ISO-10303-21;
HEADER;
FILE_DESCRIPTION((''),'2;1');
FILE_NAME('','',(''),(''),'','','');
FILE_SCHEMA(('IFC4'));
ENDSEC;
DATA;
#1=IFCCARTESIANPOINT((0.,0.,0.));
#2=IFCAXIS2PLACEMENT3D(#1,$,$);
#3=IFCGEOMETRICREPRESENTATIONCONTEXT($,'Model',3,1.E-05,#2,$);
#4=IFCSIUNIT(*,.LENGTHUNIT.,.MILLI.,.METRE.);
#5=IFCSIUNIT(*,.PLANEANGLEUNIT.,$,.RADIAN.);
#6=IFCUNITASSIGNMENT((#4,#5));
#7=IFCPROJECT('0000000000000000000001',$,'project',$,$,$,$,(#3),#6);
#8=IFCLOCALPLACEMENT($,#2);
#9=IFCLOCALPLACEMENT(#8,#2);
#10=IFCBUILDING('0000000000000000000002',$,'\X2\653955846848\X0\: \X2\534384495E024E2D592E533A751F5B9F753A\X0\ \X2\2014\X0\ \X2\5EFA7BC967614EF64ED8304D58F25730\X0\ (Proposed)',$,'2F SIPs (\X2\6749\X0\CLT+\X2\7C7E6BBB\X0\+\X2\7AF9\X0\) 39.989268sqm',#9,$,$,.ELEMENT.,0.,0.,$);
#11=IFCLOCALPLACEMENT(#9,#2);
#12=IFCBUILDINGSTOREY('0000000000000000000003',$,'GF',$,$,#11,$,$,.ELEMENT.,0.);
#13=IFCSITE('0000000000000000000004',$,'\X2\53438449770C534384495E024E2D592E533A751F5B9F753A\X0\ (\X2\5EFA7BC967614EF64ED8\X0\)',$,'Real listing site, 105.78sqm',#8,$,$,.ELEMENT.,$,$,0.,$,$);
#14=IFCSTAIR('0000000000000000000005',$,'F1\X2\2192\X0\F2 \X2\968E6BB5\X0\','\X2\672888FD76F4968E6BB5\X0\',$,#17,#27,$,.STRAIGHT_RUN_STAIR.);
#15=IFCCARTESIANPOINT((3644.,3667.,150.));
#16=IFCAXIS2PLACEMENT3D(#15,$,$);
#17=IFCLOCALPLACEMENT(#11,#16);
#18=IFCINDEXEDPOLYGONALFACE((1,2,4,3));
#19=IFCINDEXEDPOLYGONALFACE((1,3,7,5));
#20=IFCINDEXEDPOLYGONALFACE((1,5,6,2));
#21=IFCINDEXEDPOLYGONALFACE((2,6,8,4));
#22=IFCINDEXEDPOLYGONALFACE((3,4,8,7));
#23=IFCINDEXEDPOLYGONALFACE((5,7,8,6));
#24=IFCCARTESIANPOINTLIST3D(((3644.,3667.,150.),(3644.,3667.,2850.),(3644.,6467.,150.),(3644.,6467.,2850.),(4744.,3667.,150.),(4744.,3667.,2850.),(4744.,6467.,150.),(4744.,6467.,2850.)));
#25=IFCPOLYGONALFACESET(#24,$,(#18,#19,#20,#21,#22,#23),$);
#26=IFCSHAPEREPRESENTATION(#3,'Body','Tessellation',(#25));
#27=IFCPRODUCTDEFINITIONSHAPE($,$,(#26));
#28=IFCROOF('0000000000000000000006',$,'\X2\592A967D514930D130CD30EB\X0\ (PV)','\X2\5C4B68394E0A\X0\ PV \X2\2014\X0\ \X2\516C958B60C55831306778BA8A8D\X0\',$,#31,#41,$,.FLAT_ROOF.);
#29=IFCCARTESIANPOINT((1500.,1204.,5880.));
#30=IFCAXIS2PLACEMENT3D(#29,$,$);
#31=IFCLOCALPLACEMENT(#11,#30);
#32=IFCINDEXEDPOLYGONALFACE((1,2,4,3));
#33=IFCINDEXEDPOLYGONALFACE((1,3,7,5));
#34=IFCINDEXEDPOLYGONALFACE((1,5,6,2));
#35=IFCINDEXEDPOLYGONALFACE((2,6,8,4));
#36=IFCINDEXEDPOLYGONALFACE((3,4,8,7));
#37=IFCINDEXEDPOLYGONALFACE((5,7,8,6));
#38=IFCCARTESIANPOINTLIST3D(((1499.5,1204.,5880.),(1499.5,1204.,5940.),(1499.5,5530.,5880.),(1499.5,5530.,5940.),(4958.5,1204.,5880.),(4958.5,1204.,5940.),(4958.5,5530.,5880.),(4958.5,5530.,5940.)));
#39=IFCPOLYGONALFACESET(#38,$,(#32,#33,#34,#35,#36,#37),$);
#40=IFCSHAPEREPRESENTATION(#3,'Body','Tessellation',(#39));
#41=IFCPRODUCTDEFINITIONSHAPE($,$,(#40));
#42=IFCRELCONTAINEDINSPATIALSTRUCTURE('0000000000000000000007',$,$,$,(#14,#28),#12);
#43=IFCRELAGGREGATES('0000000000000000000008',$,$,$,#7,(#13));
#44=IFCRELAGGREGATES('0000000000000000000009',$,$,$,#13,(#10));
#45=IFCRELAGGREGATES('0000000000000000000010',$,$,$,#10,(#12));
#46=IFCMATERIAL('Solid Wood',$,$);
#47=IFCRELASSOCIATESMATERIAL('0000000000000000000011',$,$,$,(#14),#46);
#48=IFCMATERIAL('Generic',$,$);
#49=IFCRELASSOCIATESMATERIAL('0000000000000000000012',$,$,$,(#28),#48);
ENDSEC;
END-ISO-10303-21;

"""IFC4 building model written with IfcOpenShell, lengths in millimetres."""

from ifc_helpers import new_model, si_unit, frame, frame_2d, origin, place, context, project, spatial, rectangle, extrude, material, element, save


model = new_model("IFC4")

# Units and contexts
model_context = context("Model", 3, precision=1e-05, world=origin())
ifc_project = project(units=[si_unit("LENGTHUNIT", "METRE", prefix="MILLI"), si_unit("PLANEANGLEUNIT", "RADIAN")], contexts=[model_context])

# Site, building, storey
site_placement = place(None, origin())
site = spatial("IfcSite", under=ifc_project, at=site_placement, Name="千葉県千葉市中央区生実町 (建築条件付)", ObjectType="Real listing site, 105.78sqm", CompositionType="ELEMENT", RefElevation=0.0)
building_placement = place(site_placement, origin())
building = spatial("IfcBuilding", under=site, at=building_placement, Name="改善案: 千葉市中央区生実町 — 建築条件付き売地 (Proposed)", ObjectType="2F SIPs (杉CLT+籾殻+竹) 39.989268sqm", CompositionType="ELEMENT", ElevationOfRefHeight=0.0, ElevationOfTerrain=0.0)
storey_placement = place(building_placement, origin())
storey = spatial("IfcBuildingStorey", under=building, at=storey_placement, Name="GF", CompositionType="ELEMENT", Elevation=0.0)

# Shared definitions
ifc_material_1 = material(Name="Generic")

# Stair
ifc_material_2 = material(Name="Solid Wood")
stair_placement = place(storey_placement, frame((3644.0, 3667.0, 150.0)))
element("IfcStair", 1, at=stair_placement, inside=storey, material=ifc_material_2, Name="F1→F2 階段", Description="木製直階段", PredefinedType="STRAIGHT_RUN_STAIR", context=model_context, shape_type="SweptSolid", body=[
    extrude(rectangle(XDim=1100.0, YDim=2800.0, at=frame_2d((550.0, 1400.0))), frame((3644.0, 3667.0, 150.0)), (0.0, 0.0, 1.0), 2700.0),
])

# Roof
roof_placement = place(storey_placement, frame((1500.0, 1204.0, 5880.0)))
element("IfcRoof", 2, at=roof_placement, inside=storey, material=ifc_material_1, Name="太陽光パネル (PV)", Description="屋根上 PV — 公開情報で確認", PredefinedType="FLAT_ROOF", context=model_context, shape_type="SweptSolid", body=[
    extrude(rectangle(XDim=3459.0, YDim=4326.0, at=frame_2d((1729.0, 2163.0))), frame((1500.0, 1204.0, 5880.0)), (0.0, 0.0, 1.0), 60.0),
])

save(model, "model.ifc")
